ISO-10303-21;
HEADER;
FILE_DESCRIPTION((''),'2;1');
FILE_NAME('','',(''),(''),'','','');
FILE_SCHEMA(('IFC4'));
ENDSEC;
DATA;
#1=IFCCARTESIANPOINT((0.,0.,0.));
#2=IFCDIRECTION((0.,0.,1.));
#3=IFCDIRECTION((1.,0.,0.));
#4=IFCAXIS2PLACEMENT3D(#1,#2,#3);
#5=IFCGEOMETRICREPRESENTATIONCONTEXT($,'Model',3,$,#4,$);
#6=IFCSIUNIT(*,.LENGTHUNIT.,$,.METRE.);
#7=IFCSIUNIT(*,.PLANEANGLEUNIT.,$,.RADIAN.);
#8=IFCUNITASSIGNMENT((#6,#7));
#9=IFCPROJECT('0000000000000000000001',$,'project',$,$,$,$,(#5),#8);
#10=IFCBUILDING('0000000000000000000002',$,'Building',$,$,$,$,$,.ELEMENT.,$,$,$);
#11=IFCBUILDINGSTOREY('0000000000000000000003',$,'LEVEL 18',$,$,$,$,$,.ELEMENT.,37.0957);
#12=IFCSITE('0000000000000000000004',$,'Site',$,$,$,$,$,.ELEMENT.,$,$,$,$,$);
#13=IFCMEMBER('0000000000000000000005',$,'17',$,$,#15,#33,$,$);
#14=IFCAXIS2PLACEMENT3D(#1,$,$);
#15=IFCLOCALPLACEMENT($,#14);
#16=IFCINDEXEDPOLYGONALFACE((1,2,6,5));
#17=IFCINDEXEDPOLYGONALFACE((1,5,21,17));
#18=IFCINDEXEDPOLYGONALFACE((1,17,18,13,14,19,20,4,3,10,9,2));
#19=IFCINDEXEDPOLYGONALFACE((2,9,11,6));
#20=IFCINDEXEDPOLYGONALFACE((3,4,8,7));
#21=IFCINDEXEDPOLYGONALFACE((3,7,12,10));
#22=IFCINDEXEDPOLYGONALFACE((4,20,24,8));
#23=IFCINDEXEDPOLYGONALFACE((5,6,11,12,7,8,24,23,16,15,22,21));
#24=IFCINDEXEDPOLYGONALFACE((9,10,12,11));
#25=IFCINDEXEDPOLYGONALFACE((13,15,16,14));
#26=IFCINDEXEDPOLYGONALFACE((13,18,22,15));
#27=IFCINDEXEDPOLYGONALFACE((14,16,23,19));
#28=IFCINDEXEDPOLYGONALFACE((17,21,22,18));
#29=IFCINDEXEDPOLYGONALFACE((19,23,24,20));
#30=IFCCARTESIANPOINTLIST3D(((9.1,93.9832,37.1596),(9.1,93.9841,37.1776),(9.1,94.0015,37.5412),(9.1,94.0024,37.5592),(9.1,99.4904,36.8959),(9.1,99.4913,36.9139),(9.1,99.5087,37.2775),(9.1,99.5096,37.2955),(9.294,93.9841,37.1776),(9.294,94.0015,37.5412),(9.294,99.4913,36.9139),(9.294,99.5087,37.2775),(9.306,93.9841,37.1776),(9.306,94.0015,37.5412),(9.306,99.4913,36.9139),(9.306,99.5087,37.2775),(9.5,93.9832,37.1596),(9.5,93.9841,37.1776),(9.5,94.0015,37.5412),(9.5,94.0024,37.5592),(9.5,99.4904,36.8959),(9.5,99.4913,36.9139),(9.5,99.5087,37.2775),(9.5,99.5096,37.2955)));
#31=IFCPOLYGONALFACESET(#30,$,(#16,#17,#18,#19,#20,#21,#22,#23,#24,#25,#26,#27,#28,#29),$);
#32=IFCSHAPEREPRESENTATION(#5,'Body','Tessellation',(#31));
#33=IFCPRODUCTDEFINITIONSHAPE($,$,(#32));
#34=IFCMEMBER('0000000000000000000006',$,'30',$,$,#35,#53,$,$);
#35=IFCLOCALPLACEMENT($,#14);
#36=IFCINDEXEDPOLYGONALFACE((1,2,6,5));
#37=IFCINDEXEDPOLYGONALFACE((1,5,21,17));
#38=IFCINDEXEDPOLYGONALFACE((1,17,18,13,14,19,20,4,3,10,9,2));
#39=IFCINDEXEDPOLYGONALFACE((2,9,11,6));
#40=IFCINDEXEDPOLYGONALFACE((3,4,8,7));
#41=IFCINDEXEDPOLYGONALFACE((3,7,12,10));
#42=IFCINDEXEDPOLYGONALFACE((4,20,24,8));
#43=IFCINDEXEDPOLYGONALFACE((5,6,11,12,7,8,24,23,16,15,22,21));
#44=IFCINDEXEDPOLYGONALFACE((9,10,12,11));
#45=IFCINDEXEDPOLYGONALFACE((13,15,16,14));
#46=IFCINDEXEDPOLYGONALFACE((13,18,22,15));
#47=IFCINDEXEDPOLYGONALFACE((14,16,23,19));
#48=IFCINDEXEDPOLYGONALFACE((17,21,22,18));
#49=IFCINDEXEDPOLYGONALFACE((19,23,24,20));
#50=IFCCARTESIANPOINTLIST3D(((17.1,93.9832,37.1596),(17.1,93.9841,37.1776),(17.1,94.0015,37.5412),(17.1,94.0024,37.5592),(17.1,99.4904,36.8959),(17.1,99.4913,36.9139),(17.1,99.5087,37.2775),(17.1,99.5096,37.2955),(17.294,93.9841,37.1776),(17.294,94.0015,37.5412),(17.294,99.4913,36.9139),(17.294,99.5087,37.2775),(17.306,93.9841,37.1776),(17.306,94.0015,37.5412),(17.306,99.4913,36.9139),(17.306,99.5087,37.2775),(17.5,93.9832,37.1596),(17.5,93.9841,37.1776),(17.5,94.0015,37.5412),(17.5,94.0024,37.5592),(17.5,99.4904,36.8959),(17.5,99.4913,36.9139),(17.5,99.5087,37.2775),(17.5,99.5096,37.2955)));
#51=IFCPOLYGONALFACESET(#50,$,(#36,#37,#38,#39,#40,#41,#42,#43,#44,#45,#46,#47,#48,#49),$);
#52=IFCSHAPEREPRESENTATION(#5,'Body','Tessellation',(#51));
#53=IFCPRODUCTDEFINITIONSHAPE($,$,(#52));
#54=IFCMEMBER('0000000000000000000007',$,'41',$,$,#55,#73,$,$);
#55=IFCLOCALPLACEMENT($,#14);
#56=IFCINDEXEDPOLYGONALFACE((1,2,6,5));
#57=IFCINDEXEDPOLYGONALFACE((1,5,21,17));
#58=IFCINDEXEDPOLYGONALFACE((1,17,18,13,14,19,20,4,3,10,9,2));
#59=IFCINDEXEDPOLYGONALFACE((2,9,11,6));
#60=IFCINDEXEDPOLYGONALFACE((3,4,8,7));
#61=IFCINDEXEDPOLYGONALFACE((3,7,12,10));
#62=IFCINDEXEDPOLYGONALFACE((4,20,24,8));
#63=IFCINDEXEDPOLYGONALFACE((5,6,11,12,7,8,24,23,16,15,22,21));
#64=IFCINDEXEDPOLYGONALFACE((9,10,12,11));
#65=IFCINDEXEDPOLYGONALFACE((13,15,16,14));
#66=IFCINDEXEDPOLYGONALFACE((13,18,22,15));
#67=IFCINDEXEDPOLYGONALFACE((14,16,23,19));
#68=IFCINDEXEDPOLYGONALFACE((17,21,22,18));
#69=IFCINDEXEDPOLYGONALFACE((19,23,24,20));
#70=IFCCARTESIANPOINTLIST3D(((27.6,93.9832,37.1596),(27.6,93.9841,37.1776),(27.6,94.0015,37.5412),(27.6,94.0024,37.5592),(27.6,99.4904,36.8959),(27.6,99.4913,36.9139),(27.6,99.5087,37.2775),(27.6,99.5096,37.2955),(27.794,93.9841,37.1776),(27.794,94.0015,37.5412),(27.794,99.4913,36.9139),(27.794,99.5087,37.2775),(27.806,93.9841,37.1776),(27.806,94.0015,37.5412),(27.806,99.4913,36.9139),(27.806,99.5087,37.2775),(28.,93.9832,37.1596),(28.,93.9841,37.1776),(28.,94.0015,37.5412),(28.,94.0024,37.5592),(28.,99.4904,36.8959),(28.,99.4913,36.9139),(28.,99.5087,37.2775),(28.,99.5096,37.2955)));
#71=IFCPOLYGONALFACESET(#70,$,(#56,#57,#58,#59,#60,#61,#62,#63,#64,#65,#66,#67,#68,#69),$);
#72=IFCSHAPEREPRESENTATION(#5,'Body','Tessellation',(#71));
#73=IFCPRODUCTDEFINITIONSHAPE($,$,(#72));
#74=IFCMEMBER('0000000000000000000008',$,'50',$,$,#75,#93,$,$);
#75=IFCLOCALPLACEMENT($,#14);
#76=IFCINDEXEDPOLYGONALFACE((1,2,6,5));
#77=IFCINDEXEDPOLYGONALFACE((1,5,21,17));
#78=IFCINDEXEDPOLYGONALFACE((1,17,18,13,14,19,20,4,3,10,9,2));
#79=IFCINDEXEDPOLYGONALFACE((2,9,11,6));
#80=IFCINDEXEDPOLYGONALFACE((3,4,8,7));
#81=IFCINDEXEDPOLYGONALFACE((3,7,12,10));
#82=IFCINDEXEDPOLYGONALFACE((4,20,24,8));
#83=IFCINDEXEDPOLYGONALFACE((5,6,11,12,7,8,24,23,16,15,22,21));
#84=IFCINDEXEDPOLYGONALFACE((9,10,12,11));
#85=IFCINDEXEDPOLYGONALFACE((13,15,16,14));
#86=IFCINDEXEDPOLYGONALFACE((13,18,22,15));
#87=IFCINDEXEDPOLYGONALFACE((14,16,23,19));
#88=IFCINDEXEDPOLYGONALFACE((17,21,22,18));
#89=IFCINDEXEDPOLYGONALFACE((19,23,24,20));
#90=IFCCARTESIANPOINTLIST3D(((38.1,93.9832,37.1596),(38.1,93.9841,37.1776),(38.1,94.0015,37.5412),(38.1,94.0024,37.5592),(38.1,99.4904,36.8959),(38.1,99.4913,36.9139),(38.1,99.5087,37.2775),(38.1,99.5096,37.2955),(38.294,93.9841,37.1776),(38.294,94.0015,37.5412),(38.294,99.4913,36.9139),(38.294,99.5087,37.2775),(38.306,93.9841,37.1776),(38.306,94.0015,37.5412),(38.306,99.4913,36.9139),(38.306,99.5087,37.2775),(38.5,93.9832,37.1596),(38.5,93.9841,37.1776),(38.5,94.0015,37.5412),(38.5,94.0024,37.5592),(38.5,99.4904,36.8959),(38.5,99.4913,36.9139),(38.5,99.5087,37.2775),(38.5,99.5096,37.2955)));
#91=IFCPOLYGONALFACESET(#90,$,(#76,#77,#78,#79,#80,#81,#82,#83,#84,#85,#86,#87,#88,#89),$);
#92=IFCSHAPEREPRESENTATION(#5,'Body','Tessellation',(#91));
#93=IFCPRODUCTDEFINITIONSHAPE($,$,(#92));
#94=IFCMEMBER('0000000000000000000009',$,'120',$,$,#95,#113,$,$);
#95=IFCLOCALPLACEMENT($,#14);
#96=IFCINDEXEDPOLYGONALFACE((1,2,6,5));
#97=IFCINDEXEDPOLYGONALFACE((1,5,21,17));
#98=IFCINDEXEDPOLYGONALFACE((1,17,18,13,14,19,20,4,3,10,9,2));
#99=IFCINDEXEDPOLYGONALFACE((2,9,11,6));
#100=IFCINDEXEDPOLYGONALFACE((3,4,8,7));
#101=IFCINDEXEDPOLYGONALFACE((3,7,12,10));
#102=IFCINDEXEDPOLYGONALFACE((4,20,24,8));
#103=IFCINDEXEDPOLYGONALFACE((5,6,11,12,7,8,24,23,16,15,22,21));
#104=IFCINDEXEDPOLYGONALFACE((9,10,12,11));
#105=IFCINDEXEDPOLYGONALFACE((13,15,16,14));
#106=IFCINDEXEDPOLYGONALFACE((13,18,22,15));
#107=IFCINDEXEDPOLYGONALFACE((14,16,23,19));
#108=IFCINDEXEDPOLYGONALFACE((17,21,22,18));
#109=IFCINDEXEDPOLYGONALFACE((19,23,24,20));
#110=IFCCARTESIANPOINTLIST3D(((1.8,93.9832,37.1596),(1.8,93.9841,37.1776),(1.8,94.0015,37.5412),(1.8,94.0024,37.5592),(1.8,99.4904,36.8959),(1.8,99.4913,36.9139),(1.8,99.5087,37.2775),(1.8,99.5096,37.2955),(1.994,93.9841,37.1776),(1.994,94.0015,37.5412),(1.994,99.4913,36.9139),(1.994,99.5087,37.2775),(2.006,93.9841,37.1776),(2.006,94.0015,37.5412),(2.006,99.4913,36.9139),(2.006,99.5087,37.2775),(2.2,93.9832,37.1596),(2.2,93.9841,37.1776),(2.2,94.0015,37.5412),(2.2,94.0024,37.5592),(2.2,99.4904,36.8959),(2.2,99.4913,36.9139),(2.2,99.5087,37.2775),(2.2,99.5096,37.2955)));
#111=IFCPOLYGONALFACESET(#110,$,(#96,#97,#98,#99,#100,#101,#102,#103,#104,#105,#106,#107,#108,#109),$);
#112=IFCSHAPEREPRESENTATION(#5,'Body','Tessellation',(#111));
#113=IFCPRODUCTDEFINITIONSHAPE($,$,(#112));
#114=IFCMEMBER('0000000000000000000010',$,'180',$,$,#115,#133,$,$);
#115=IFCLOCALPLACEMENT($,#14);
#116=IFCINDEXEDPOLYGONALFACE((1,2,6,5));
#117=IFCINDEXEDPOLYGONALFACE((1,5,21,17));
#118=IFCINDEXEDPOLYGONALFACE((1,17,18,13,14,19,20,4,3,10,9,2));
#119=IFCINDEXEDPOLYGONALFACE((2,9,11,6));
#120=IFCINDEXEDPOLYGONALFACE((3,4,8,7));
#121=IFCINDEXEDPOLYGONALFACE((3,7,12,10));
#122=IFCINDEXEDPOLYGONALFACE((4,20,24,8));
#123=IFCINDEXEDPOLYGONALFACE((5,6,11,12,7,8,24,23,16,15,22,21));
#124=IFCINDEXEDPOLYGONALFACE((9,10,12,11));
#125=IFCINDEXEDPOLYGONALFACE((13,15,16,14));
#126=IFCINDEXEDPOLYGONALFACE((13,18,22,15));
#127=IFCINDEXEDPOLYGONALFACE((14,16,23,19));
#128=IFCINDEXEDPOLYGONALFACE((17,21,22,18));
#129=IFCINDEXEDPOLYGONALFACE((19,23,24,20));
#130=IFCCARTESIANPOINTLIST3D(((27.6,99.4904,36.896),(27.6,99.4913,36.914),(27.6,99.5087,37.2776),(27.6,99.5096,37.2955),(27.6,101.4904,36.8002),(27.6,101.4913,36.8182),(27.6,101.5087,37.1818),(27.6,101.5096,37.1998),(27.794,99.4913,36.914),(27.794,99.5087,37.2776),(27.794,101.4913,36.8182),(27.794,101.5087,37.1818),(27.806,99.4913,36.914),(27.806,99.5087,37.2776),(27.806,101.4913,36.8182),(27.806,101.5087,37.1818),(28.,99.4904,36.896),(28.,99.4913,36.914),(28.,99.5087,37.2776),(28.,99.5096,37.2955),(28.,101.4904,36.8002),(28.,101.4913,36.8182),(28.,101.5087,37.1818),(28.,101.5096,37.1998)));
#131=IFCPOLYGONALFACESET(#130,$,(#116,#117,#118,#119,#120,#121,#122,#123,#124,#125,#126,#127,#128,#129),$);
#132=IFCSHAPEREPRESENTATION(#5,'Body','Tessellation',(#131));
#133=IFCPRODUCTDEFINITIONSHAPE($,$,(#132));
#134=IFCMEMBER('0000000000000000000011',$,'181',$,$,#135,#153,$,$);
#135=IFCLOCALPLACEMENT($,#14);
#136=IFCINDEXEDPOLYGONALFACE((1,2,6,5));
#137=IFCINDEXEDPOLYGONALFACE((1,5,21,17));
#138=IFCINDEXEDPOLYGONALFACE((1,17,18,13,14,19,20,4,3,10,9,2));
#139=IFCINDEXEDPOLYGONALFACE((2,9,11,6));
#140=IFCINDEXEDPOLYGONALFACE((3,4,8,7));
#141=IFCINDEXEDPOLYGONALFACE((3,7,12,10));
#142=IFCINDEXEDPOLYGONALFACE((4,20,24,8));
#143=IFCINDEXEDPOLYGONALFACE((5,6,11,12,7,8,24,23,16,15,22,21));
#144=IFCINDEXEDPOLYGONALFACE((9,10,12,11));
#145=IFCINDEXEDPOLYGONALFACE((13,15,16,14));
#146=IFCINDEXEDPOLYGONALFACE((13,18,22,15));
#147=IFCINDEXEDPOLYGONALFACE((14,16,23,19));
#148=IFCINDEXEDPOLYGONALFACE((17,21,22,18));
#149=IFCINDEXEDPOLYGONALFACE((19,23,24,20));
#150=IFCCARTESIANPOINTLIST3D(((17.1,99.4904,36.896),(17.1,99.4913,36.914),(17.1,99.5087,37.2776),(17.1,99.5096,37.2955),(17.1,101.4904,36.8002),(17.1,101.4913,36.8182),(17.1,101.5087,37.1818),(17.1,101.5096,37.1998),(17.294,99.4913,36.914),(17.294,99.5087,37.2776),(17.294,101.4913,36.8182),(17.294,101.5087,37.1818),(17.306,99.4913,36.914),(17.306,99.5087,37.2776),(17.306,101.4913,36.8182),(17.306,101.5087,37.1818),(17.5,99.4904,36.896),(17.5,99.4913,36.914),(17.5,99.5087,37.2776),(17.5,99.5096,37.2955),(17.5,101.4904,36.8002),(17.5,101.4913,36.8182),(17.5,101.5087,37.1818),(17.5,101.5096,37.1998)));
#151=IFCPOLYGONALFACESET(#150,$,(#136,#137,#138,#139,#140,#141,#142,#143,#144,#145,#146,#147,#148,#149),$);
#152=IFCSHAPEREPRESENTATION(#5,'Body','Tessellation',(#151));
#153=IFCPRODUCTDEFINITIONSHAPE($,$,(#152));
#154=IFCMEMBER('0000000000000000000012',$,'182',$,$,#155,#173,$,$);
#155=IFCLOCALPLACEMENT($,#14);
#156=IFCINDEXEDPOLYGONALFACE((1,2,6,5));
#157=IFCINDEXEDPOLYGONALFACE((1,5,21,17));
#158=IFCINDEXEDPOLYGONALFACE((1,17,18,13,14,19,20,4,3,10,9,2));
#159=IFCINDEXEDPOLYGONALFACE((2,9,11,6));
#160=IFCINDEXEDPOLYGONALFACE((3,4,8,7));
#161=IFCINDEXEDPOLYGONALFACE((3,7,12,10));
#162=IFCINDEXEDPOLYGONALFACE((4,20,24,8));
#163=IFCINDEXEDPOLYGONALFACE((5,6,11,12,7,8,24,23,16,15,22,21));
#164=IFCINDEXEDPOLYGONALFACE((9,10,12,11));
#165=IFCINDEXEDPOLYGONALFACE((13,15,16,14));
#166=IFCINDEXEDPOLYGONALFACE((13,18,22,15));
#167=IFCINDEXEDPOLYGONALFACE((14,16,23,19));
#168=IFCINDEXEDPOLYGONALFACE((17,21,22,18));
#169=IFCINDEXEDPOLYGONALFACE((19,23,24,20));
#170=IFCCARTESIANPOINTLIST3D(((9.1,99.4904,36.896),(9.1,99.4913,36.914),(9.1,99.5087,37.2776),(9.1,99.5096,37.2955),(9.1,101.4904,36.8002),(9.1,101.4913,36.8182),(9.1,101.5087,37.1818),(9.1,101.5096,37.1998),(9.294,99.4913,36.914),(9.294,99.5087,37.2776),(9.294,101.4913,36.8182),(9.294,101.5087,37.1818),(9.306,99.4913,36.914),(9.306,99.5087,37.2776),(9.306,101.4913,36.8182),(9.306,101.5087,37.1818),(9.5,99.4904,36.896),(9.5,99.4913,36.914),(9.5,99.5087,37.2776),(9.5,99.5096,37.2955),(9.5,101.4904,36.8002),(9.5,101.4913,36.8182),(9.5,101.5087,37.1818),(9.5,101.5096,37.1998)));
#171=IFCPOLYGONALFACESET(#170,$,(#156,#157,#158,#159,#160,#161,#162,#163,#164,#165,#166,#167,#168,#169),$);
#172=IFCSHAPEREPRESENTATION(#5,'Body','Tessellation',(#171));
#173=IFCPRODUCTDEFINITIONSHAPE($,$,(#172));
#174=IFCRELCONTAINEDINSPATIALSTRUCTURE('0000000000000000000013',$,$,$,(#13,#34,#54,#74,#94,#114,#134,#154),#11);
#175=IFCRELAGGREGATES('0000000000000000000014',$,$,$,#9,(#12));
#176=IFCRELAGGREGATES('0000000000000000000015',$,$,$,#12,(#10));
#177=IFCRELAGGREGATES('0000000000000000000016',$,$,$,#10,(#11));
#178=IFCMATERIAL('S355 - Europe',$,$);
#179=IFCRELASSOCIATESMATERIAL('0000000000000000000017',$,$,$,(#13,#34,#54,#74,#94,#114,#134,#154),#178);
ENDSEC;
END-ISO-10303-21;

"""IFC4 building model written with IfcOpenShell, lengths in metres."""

from ifc_helpers import new_model, si_unit, frame, origin_with_axes, origin_2d_with_axis, place, context, project, spatial, i_section, extrude, material, material_profile, profile_set, profile_usage, element, save


model = new_model("IFC4")

# Units and contexts
model_context = context("Model", 3, world=origin_with_axes())
ifc_project = project(units=[si_unit("LENGTHUNIT", "METRE"), si_unit("PLANEANGLEUNIT", "RADIAN")], contexts=[model_context])

# Site, building, storey
site = spatial("IfcSite", under=ifc_project, Name="Site", CompositionType="ELEMENT")
building = spatial("IfcBuilding", under=site, Name="Building", CompositionType="ELEMENT")
storey = spatial("IfcBuildingStorey", under=building, Name="LEVEL 18", CompositionType="ELEMENT", Elevation=37.0957)

# Shared definitions
ifc_material = material(Name="S355 - Europe")

# Members
ifc_material_profile_1 = material_profile(ifc_material, i_section(OverallWidth=0.4, OverallDepth=0.4, WebThickness=0.012, FlangeThickness=0.018, at=origin_2d_with_axis()))
ifc_profile_set_1 = profile_set([ifc_material_profile_1])
ifc_profile_usage_1 = profile_usage(ifc_profile_set_1, cardinal=10)
member_1_placement = place(None, frame((9.3, 99.5, 37.0957), z_axis=(0.0, -0.998856, 0.047828), x_axis=(1.0, 0.0, 0.0)))
element("IfcMember", 1, at=member_1_placement, inside=storey, material=ifc_profile_usage_1, Name="17", context=model_context, shape_type="SweptSolid", body=[
    extrude(i_section(OverallWidth=0.4, OverallDepth=0.4, WebThickness=0.012, FlangeThickness=0.018, at=origin_2d_with_axis()), origin_with_axes(), (0.0, 0.0, 1.0), 5.5135),
])
ifc_material_profile_2 = material_profile(ifc_material, i_section(OverallWidth=0.4, OverallDepth=0.4, WebThickness=0.012, FlangeThickness=0.018, at=origin_2d_with_axis()))
ifc_profile_set_2 = profile_set([ifc_material_profile_2])
ifc_profile_usage_2 = profile_usage(ifc_profile_set_2, cardinal=10)
member_2_placement = place(None, frame((17.3, 99.5, 37.0957), z_axis=(0.0, -0.998856, 0.047828), x_axis=(1.0, 0.0, 0.0)))
element("IfcMember", 2, at=member_2_placement, inside=storey, material=ifc_profile_usage_2, Name="30", context=model_context, shape_type="SweptSolid", body=[
    extrude(i_section(OverallWidth=0.4, OverallDepth=0.4, WebThickness=0.012, FlangeThickness=0.018, at=origin_2d_with_axis()), origin_with_axes(), (0.0, 0.0, 1.0), 5.5135),
])
ifc_material_profile_3 = material_profile(ifc_material, i_section(OverallWidth=0.4, OverallDepth=0.4, WebThickness=0.012, FlangeThickness=0.018, at=origin_2d_with_axis()))
ifc_profile_set_3 = profile_set([ifc_material_profile_3])
ifc_profile_usage_3 = profile_usage(ifc_profile_set_3, cardinal=10)
member_3_placement = place(None, frame((27.8, 99.5, 37.0957), z_axis=(0.0, -0.998856, 0.047828), x_axis=(1.0, 0.0, 0.0)))
element("IfcMember", 3, at=member_3_placement, inside=storey, material=ifc_profile_usage_3, Name="41", context=model_context, shape_type="SweptSolid", body=[
    extrude(i_section(OverallWidth=0.4, OverallDepth=0.4, WebThickness=0.012, FlangeThickness=0.018, at=origin_2d_with_axis()), origin_with_axes(), (0.0, 0.0, 1.0), 5.5135),
])
ifc_material_profile_4 = material_profile(ifc_material, i_section(OverallWidth=0.4, OverallDepth=0.4, WebThickness=0.012, FlangeThickness=0.018, at=origin_2d_with_axis()))
ifc_profile_set_4 = profile_set([ifc_material_profile_4])
ifc_profile_usage_4 = profile_usage(ifc_profile_set_4, cardinal=10)
member_4_placement = place(None, frame((38.3, 99.5, 37.0957), z_axis=(0.0, -0.998856, 0.047828), x_axis=(1.0, 0.0, 0.0)))
element("IfcMember", 4, at=member_4_placement, inside=storey, material=ifc_profile_usage_4, Name="50", context=model_context, shape_type="SweptSolid", body=[
    extrude(i_section(OverallWidth=0.4, OverallDepth=0.4, WebThickness=0.012, FlangeThickness=0.018, at=origin_2d_with_axis()), origin_with_axes(), (0.0, 0.0, 1.0), 5.5135),
])
ifc_material_profile_5 = material_profile(ifc_material, i_section(OverallWidth=0.4, OverallDepth=0.4, WebThickness=0.012, FlangeThickness=0.018, at=origin_2d_with_axis()))
ifc_profile_set_5 = profile_set([ifc_material_profile_5])
ifc_profile_usage_5 = profile_usage(ifc_profile_set_5, cardinal=10)
member_5_placement = place(None, frame((2.0, 99.5, 37.0957), z_axis=(0.0, -0.998856, 0.047828), x_axis=(1.0, 0.0, 0.0)))
element("IfcMember", 5, at=member_5_placement, inside=storey, material=ifc_profile_usage_5, Name="120", context=model_context, shape_type="SweptSolid", body=[
    extrude(i_section(OverallWidth=0.4, OverallDepth=0.4, WebThickness=0.012, FlangeThickness=0.018, at=origin_2d_with_axis()), origin_with_axes(), (0.0, 0.0, 1.0), 5.5135),
])
ifc_material_profile_6 = material_profile(ifc_material, i_section(OverallWidth=0.4, OverallDepth=0.4, WebThickness=0.012, FlangeThickness=0.018, at=origin_2d_with_axis()))
ifc_profile_set_6 = profile_set([ifc_material_profile_6])
ifc_profile_usage_6 = profile_usage(ifc_profile_set_6, cardinal=10)
member_6_placement = place(None, frame((27.8, 101.5, 37.0), z_axis=(0.0, -0.998856, 0.047828), x_axis=(1.0, 0.0, 0.0)))
element("IfcMember", 6, at=member_6_placement, inside=storey, material=ifc_profile_usage_6, Name="180", context=model_context, shape_type="SweptSolid", body=[
    extrude(i_section(OverallWidth=0.4, OverallDepth=0.4, WebThickness=0.012, FlangeThickness=0.018, at=origin_2d_with_axis()), origin_with_axes(), (0.0, 0.0, 1.0), 2.0023),
])
ifc_material_profile_7 = material_profile(ifc_material, i_section(OverallWidth=0.4, OverallDepth=0.4, WebThickness=0.012, FlangeThickness=0.018, at=origin_2d_with_axis()))
ifc_profile_set_7 = profile_set([ifc_material_profile_7])
ifc_profile_usage_7 = profile_usage(ifc_profile_set_7, cardinal=10)
member_7_placement = place(None, frame((17.3, 101.5, 37.0), z_axis=(0.0, -0.998856, 0.047828), x_axis=(1.0, 0.0, 0.0)))
element("IfcMember", 7, at=member_7_placement, inside=storey, material=ifc_profile_usage_7, Name="181", context=model_context, shape_type="SweptSolid", body=[
    extrude(i_section(OverallWidth=0.4, OverallDepth=0.4, WebThickness=0.012, FlangeThickness=0.018, at=origin_2d_with_axis()), origin_with_axes(), (0.0, 0.0, 1.0), 2.0023),
])
ifc_material_profile_8 = material_profile(ifc_material, i_section(OverallWidth=0.4, OverallDepth=0.4, WebThickness=0.012, FlangeThickness=0.018, at=origin_2d_with_axis()))
ifc_profile_set_8 = profile_set([ifc_material_profile_8])
ifc_profile_usage_8 = profile_usage(ifc_profile_set_8, cardinal=10)
member_8_placement = place(None, frame((9.3, 101.5, 37.0), z_axis=(0.0, -0.998856, 0.047828), x_axis=(1.0, 0.0, 0.0)))
element("IfcMember", 8, at=member_8_placement, inside=storey, material=ifc_profile_usage_8, Name="182", context=model_context, shape_type="SweptSolid", body=[
    extrude(i_section(OverallWidth=0.4, OverallDepth=0.4, WebThickness=0.012, FlangeThickness=0.018, at=origin_2d_with_axis()), origin_with_axes(), (0.0, 0.0, 1.0), 2.0023),
])

save(model, "model.ifc")
